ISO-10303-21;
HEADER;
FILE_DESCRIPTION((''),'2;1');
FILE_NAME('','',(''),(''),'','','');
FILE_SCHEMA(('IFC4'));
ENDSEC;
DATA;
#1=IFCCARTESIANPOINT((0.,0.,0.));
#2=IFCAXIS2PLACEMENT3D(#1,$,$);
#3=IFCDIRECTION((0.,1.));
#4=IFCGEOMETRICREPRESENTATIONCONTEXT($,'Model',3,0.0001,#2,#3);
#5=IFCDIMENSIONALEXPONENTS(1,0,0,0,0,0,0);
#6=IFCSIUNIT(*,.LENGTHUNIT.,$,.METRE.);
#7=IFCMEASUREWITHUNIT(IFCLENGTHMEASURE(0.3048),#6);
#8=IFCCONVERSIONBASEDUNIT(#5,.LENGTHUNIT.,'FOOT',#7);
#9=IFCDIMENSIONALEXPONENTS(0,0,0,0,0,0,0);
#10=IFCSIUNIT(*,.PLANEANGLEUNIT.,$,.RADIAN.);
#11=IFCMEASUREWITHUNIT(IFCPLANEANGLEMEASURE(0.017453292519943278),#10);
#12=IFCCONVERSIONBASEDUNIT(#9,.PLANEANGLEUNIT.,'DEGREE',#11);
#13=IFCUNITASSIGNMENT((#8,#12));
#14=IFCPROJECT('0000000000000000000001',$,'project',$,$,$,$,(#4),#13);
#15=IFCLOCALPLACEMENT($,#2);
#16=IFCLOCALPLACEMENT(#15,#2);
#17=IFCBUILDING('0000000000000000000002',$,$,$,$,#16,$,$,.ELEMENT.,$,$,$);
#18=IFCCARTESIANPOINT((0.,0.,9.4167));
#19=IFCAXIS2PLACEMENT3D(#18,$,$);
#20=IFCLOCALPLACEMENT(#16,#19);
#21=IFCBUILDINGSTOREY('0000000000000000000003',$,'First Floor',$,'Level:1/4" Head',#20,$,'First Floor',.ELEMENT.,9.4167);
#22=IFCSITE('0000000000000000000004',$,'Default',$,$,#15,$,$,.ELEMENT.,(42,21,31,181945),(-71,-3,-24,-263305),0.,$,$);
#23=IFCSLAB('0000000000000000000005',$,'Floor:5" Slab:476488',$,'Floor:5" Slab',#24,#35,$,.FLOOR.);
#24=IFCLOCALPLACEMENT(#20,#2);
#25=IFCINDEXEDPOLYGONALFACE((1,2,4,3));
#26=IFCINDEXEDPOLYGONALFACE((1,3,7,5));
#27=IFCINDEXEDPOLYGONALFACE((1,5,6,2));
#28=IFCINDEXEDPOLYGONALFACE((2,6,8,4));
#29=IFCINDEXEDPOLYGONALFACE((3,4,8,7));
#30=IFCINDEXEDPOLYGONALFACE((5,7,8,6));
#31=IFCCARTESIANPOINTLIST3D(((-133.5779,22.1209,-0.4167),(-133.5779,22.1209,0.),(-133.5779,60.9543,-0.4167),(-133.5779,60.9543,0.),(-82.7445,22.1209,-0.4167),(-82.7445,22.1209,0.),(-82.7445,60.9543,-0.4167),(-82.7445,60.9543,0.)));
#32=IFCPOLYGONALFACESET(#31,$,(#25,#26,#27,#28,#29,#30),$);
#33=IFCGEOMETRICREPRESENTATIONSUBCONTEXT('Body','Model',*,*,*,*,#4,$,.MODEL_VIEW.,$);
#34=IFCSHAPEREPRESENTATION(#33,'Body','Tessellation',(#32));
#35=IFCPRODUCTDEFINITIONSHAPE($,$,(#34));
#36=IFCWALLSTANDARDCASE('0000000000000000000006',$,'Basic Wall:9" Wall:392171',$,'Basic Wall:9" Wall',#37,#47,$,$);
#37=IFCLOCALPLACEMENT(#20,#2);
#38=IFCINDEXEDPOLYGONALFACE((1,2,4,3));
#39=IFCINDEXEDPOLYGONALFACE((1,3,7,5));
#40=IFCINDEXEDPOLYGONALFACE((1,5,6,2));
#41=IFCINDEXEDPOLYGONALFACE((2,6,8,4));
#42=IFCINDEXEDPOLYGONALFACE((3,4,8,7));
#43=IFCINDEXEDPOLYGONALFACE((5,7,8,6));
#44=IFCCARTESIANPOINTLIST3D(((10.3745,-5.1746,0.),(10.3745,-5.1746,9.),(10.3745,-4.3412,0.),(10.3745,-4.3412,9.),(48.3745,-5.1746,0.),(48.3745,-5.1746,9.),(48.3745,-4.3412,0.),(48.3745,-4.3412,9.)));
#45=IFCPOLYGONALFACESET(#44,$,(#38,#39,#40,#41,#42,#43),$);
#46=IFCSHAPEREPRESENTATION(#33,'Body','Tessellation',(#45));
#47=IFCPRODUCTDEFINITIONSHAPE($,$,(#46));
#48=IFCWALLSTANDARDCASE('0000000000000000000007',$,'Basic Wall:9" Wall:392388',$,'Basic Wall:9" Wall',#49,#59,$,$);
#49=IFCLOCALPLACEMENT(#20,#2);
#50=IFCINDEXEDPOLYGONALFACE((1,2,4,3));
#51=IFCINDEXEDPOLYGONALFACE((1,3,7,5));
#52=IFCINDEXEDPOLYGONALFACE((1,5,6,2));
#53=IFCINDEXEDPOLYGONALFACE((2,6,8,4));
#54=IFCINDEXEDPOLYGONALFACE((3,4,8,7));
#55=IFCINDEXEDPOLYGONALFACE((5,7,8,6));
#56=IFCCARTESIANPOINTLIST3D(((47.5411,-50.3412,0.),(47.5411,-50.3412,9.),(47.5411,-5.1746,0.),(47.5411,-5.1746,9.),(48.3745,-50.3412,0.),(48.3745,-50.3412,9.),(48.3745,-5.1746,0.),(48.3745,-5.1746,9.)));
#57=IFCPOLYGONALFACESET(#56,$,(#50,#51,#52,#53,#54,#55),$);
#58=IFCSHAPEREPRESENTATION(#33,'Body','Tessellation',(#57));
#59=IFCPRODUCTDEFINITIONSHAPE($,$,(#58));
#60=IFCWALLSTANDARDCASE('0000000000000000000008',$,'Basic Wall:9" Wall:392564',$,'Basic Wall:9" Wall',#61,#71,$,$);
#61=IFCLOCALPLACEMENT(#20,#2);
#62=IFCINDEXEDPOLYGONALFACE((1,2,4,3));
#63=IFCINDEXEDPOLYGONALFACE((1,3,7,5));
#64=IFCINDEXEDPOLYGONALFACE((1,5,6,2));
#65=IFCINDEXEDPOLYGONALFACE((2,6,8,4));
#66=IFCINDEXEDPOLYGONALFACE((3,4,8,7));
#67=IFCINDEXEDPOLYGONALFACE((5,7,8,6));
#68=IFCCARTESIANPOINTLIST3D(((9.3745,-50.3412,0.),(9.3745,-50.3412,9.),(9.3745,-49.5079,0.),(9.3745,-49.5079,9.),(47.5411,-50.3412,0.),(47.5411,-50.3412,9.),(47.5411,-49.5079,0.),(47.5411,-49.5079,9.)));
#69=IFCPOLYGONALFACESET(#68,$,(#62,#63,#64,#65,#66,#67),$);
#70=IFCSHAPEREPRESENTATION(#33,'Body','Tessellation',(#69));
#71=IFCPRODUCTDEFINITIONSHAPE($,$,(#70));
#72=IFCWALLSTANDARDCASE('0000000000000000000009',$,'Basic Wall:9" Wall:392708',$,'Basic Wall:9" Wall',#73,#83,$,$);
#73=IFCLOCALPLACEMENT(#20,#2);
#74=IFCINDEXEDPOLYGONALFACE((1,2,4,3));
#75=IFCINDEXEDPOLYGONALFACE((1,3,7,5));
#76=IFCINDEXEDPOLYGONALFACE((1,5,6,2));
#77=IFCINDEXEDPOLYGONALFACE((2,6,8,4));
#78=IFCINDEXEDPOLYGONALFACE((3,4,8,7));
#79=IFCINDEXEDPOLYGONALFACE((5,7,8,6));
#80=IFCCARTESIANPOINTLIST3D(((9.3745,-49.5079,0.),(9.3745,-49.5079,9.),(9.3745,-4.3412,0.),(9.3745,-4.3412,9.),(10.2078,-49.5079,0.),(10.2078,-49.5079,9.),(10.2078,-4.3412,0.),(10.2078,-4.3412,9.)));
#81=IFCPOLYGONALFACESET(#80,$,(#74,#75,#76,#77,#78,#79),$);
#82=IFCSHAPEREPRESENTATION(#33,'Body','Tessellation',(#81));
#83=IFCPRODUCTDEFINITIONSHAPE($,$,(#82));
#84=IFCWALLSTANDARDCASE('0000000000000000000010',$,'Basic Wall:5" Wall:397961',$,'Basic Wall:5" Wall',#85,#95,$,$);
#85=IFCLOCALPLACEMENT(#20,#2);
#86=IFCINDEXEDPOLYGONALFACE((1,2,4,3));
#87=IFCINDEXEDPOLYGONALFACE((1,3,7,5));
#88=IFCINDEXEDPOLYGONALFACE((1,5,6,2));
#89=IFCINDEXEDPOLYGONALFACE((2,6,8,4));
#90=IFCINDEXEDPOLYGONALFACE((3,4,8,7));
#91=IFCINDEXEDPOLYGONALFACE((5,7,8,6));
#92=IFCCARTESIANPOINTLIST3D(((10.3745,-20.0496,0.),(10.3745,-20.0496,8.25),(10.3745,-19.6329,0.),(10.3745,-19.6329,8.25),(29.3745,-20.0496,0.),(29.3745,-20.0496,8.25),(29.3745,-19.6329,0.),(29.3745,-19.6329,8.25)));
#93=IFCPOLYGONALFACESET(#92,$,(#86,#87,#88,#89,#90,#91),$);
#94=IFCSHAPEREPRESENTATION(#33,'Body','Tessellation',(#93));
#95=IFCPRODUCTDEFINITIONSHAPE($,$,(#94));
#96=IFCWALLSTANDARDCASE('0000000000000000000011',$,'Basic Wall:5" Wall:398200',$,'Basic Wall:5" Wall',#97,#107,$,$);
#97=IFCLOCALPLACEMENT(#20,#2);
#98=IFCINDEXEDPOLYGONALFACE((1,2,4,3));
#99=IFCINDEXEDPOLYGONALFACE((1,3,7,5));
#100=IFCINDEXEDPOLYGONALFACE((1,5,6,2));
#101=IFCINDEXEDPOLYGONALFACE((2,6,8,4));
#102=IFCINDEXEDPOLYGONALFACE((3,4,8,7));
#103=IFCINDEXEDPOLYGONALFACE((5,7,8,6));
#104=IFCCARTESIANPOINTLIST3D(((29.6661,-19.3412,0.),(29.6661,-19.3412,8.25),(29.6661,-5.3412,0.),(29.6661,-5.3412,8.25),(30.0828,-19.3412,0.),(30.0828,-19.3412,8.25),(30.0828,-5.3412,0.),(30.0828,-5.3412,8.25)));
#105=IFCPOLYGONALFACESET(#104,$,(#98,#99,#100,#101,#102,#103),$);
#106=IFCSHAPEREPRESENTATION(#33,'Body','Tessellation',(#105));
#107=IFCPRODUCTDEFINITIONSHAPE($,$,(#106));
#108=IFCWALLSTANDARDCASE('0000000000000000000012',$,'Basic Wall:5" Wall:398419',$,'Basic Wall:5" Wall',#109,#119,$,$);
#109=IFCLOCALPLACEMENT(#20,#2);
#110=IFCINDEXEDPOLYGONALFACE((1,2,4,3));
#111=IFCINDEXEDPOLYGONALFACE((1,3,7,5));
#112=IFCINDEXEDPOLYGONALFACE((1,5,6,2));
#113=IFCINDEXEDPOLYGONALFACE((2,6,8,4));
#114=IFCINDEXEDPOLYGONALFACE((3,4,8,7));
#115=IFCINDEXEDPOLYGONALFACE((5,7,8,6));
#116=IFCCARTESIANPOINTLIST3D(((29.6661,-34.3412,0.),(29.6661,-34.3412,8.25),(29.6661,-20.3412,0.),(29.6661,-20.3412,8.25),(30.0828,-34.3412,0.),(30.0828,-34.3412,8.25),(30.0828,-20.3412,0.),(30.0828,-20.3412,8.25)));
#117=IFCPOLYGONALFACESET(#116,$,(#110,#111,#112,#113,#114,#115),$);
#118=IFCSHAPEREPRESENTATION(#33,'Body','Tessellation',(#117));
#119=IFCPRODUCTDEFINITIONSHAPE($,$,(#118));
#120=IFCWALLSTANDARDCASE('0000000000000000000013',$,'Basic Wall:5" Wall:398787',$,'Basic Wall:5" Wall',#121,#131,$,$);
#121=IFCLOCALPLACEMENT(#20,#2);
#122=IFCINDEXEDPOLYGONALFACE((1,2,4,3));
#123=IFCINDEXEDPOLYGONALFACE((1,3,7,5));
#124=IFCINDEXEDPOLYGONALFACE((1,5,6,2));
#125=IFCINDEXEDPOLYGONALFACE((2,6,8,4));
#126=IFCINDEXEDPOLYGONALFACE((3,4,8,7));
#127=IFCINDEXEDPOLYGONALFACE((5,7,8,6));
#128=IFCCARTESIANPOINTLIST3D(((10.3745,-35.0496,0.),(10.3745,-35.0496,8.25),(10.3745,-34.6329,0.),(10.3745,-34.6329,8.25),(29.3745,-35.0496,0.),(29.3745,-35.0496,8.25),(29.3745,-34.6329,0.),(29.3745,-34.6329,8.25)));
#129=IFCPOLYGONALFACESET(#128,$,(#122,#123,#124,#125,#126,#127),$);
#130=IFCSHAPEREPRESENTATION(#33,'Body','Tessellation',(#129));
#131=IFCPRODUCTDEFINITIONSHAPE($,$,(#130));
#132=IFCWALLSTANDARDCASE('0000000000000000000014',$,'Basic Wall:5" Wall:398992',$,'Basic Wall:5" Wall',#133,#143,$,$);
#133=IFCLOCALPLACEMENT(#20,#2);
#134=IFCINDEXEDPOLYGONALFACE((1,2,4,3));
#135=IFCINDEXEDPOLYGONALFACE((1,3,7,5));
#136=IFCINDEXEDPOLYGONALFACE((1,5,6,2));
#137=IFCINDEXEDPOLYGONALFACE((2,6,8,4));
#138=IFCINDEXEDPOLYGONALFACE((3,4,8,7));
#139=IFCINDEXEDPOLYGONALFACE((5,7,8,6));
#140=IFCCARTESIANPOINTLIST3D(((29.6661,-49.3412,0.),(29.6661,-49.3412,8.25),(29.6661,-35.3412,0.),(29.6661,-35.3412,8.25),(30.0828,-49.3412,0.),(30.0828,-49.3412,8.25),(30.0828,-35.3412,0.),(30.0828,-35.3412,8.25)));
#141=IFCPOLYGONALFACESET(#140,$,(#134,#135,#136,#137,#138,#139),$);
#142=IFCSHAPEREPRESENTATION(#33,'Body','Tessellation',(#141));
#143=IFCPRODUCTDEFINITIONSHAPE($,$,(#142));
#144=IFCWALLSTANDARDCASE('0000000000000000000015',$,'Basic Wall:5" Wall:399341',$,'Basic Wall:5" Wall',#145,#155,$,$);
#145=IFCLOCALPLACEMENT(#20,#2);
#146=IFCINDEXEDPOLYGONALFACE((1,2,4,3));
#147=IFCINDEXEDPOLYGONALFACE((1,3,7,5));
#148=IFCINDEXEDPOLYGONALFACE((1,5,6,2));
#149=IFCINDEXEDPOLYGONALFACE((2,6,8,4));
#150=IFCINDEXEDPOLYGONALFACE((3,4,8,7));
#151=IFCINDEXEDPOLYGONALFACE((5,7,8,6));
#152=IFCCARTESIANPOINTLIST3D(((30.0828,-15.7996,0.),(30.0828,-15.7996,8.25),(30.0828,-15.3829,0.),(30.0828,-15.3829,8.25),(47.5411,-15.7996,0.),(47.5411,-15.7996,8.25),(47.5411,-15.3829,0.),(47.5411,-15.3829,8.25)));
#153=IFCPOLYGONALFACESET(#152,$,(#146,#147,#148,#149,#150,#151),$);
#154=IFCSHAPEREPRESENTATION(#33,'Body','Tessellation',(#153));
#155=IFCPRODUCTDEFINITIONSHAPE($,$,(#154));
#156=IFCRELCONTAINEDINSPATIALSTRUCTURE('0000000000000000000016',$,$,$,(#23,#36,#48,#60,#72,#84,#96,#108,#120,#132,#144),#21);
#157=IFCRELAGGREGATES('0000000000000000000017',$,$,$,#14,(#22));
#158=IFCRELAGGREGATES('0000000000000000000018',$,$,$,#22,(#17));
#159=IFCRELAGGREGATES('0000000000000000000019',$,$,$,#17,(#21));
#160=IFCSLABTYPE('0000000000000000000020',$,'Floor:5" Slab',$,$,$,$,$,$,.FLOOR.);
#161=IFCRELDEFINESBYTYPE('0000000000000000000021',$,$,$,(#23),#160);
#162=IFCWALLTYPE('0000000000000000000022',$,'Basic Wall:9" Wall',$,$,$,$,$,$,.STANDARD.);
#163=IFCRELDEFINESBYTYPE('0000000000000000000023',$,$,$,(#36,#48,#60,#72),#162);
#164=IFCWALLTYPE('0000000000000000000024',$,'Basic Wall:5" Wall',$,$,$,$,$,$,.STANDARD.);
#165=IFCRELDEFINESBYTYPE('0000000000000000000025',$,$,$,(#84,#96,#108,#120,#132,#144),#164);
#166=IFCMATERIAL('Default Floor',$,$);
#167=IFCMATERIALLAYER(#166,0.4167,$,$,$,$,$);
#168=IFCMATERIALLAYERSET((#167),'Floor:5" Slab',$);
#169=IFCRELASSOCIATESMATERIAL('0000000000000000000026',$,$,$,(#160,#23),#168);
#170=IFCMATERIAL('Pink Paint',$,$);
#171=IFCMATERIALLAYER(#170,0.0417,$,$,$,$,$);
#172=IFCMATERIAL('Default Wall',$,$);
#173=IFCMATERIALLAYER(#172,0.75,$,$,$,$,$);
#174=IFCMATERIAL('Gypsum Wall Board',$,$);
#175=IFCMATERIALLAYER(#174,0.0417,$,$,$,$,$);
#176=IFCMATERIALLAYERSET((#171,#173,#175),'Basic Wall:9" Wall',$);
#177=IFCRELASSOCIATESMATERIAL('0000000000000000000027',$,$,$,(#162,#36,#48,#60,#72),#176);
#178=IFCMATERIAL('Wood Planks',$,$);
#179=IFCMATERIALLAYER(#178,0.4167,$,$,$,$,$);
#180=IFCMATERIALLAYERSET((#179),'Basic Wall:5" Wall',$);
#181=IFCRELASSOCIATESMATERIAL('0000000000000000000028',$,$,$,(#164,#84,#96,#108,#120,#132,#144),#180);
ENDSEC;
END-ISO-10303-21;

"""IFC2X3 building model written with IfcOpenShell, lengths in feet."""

from ifc_helpers import new_model, entity, si_unit, converted_unit, direction, frame, frame_2d, origin, place, context, subcontext, project, spatial, rectangle, extrude, material, layer, layer_set, layer_usage, type_object, element, save


model = new_model("IFC2X3")

# Units and contexts
model_context = context("Model", 3, precision=0.0001, world=origin(), true_north=direction((0.0, 1.0)))
body_context = subcontext(model_context, "Body", "Model", "MODEL_VIEW")
ifc_project = project(units=[converted_unit("LENGTHUNIT", "FOOT", entity("IfcLengthMeasure", 0.3048), si_unit("LENGTHUNIT", "METRE"), dimensions=[1, 0, 0, 0, 0, 0, 0]), converted_unit("PLANEANGLEUNIT", "DEGREE", entity("IfcPlaneAngleMeasure", 0.017453292519943278), si_unit("PLANEANGLEUNIT", "RADIAN"), dimensions=[0, 0, 0, 0, 0, 0, 0])], contexts=[model_context])

# Site, building, storey
site_placement = place(None, origin())
site = spatial("IfcSite", under=ifc_project, at=site_placement, Name="Default", CompositionType="ELEMENT", RefLatitude=(42, 21, 31, 181945), RefLongitude=(-71, -3, -24, -263305), RefElevation=0.0)
building_placement = place(site_placement, origin())
building = spatial("IfcBuilding", under=site, at=building_placement, CompositionType="ELEMENT")
storey_placement = place(building_placement, frame((0.0, 0.0, 9.4167)))
storey = spatial("IfcBuildingStorey", under=building, at=storey_placement, Name="First Floor", ObjectType="Level:1/4\" Head", LongName="First Floor", CompositionType="ELEMENT", Elevation=9.4167)

# Shared definitions
ifc_material_1 = material(Name="Default Floor")
ifc_layer_1 = layer(ifc_material_1, 0.4167)
ifc_layer_set_1 = layer_set([ifc_layer_1], Name="Floor:5\" Slab")
ifc_layer_usage_1 = layer_usage(ifc_layer_set_1, "AXIS3", "POSITIVE", 0.0)
slab_type = type_object("IfcSlabType", Name="Floor:5\" Slab", PredefinedType="FLOOR", material=ifc_layer_set_1)

# Slab
slab_1_placement = place(storey_placement, origin())
element("IfcSlab", 1, at=slab_1_placement, inside=storey, type_object=slab_type, material=ifc_layer_usage_1, Name="Floor:5\" Slab:476488", ObjectType="Floor:5\" Slab", PredefinedType="FLOOR", context=body_context, shape_type="SweptSolid", body=[
    extrude(rectangle(XDim=38.8333, YDim=50.8333, at=frame_2d((0.0, 0.0), x_axis=(1.0, 0.0))), frame((-108.1612, 41.5376, 0.0), z_axis=(0.0, 0.0, -1.0), x_axis=(0.0, 1.0, 0.0)), (0.0, 0.0, 1.0), 0.4167),
])

# Walls
ifc_material_2 = material(Name="Pink Paint")
ifc_layer_2 = layer(ifc_material_2, 0.0417)
ifc_material_3 = material(Name="Default Wall")
ifc_layer_3 = layer(ifc_material_3, 0.75)
ifc_material_4 = material(Name="Gypsum Wall Board")
ifc_layer_4 = layer(ifc_material_4, 0.0417)
ifc_layer_set_2 = layer_set([ifc_layer_2, ifc_layer_3, ifc_layer_4], Name="Basic Wall:9\" Wall")
ifc_layer_usage_2 = layer_usage(ifc_layer_set_2, "AXIS2", "NEGATIVE", 0.4167)
wall_type_1 = type_object("IfcWallType", Name="Basic Wall:9\" Wall", PredefinedType="STANDARD", material=ifc_layer_set_2)
wall_1_placement = place(storey_placement, frame((10.3745, -4.7579, 0.0)))
element("IfcWallStandardCase", 2, at=wall_1_placement, inside=storey, type_object=wall_type_1, material=ifc_layer_usage_2, Name="Basic Wall:9\" Wall:392171", ObjectType="Basic Wall:9\" Wall", context=body_context, shape_type="SweptSolid", body=[
    extrude(rectangle(XDim=38.0, YDim=0.8333, at=frame_2d((19.0, 0.0), x_axis=(-1.0, 0.0))), origin(), (0.0, 0.0, 1.0), 9.0),
])
wall_2_placement = place(storey_placement, frame((47.9578, -5.1746, 0.0), z_axis=(0.0, 0.0, 1.0), x_axis=(0.0, -1.0, 0.0)))
element("IfcWallStandardCase", 3, at=wall_2_placement, inside=storey, type_object=wall_type_1, material=ifc_layer_usage_2, Name="Basic Wall:9\" Wall:392388", ObjectType="Basic Wall:9\" Wall", context=body_context, shape_type="SweptSolid", body=[
    extrude(rectangle(XDim=45.1667, YDim=0.8333, at=frame_2d((22.5833, 0.0), x_axis=(-1.0, 0.0))), origin(), (0.0, 0.0, 1.0), 9.0),
])
wall_3_placement = place(storey_placement, frame((47.5411, -49.9246, 0.0), z_axis=(0.0, 0.0, 1.0), x_axis=(-1.0, 0.0, 0.0)))
element("IfcWallStandardCase", 4, at=wall_3_placement, inside=storey, type_object=wall_type_1, material=ifc_layer_usage_2, Name="Basic Wall:9\" Wall:392564", ObjectType="Basic Wall:9\" Wall", context=body_context, shape_type="SweptSolid", body=[
    extrude(rectangle(XDim=38.1667, YDim=0.8333, at=frame_2d((19.0833, 0.0), x_axis=(-1.0, 0.0))), origin(), (0.0, 0.0, 1.0), 9.0),
])
wall_4_placement = place(storey_placement, frame((9.7911, -49.5079, 0.0), z_axis=(0.0, 0.0, 1.0), x_axis=(0.0, 1.0, 0.0)))
element("IfcWallStandardCase", 5, at=wall_4_placement, inside=storey, type_object=wall_type_1, material=ifc_layer_usage_2, Name="Basic Wall:9\" Wall:392708", ObjectType="Basic Wall:9\" Wall", context=body_context, shape_type="SweptSolid", body=[
    extrude(rectangle(XDim=45.1667, YDim=0.8333, at=frame_2d((22.5833, 0.0), x_axis=(-1.0, 0.0))), origin(), (0.0, 0.0, 1.0), 9.0),
])
ifc_material_5 = material(Name="Wood Planks")
ifc_layer_5 = layer(ifc_material_5, 0.4167)
ifc_layer_set_3 = layer_set([ifc_layer_5], Name="Basic Wall:5\" Wall")
ifc_layer_usage_3 = layer_usage(ifc_layer_set_3, "AXIS2", "NEGATIVE", 0.2083)
wall_type_2 = type_object("IfcWallType", Name="Basic Wall:5\" Wall", PredefinedType="STANDARD", material=ifc_layer_set_3)
wall_5_placement = place(storey_placement, frame((10.3745, -19.8412, 0.0)))
element("IfcWallStandardCase", 6, at=wall_5_placement, inside=storey, type_object=wall_type_2, material=ifc_layer_usage_3, Name="Basic Wall:5\" Wall:397961", ObjectType="Basic Wall:5\" Wall", context=body_context, shape_type="SweptSolid", body=[
    extrude(rectangle(XDim=19.0, YDim=0.4167, at=frame_2d((9.5, 0.0), x_axis=(-1.0, 0.0))), origin(), (0.0, 0.0, 1.0), 8.25),
])
wall_6_placement = place(storey_placement, frame((29.8745, -19.3412, 0.0), z_axis=(0.0, 0.0, 1.0), x_axis=(0.0, 1.0, 0.0)))
element("IfcWallStandardCase", 7, at=wall_6_placement, inside=storey, type_object=wall_type_2, material=ifc_layer_usage_3, Name="Basic Wall:5\" Wall:398200", ObjectType="Basic Wall:5\" Wall", context=body_context, shape_type="SweptSolid", body=[
    extrude(rectangle(XDim=14.0, YDim=0.4167, at=frame_2d((7.0, 0.0), x_axis=(-1.0, 0.0))), origin(), (0.0, 0.0, 1.0), 8.25),
])
wall_7_placement = place(storey_placement, frame((29.8745, -20.3412, 0.0), z_axis=(0.0, 0.0, 1.0), x_axis=(0.0, -1.0, 0.0)))
element("IfcWallStandardCase", 8, at=wall_7_placement, inside=storey, type_object=wall_type_2, material=ifc_layer_usage_3, Name="Basic Wall:5\" Wall:398419", ObjectType="Basic Wall:5\" Wall", context=body_context, shape_type="SweptSolid", body=[
    extrude(rectangle(XDim=14.0, YDim=0.4167, at=frame_2d((7.0, 0.0), x_axis=(-1.0, 0.0))), origin(), (0.0, 0.0, 1.0), 8.25),
])
wall_8_placement = place(storey_placement, frame((29.3745, -34.8412, 0.0), z_axis=(0.0, 0.0, 1.0), x_axis=(-1.0, 0.0, 0.0)))
element("IfcWallStandardCase", 9, at=wall_8_placement, inside=storey, type_object=wall_type_2, material=ifc_layer_usage_3, Name="Basic Wall:5\" Wall:398787", ObjectType="Basic Wall:5\" Wall", context=body_context, shape_type="SweptSolid", body=[
    extrude(rectangle(XDim=19.0, YDim=0.4167, at=frame_2d((9.5, 0.0), x_axis=(-1.0, 0.0))), origin(), (0.0, 0.0, 1.0), 8.25),
])
wall_9_placement = place(storey_placement, frame((29.8745, -35.3412, 0.0), z_axis=(0.0, 0.0, 1.0), x_axis=(0.0, -1.0, 0.0)))
element("IfcWallStandardCase", 10, at=wall_9_placement, inside=storey, type_object=wall_type_2, material=ifc_layer_usage_3, Name="Basic Wall:5\" Wall:398992", ObjectType="Basic Wall:5\" Wall", context=body_context, shape_type="SweptSolid", body=[
    extrude(rectangle(XDim=14.0, YDim=0.4167, at=frame_2d((7.0, 0.0), x_axis=(-1.0, 0.0))), origin(), (0.0, 0.0, 1.0), 8.25),
])
wall_10_placement = place(storey_placement, frame((30.0828, -15.5912, 0.0)))
element("IfcWallStandardCase", 11, at=wall_10_placement, inside=storey, type_object=wall_type_2, material=ifc_layer_usage_3, Name="Basic Wall:5\" Wall:399341", ObjectType="Basic Wall:5\" Wall", context=body_context, shape_type="SweptSolid", body=[
    extrude(rectangle(XDim=17.4583, YDim=0.4167, at=frame_2d((8.7292, 0.0), x_axis=(-1.0, 0.0))), origin(), (0.0, 0.0, 1.0), 8.25),
])

save(model, "model.ifc")
